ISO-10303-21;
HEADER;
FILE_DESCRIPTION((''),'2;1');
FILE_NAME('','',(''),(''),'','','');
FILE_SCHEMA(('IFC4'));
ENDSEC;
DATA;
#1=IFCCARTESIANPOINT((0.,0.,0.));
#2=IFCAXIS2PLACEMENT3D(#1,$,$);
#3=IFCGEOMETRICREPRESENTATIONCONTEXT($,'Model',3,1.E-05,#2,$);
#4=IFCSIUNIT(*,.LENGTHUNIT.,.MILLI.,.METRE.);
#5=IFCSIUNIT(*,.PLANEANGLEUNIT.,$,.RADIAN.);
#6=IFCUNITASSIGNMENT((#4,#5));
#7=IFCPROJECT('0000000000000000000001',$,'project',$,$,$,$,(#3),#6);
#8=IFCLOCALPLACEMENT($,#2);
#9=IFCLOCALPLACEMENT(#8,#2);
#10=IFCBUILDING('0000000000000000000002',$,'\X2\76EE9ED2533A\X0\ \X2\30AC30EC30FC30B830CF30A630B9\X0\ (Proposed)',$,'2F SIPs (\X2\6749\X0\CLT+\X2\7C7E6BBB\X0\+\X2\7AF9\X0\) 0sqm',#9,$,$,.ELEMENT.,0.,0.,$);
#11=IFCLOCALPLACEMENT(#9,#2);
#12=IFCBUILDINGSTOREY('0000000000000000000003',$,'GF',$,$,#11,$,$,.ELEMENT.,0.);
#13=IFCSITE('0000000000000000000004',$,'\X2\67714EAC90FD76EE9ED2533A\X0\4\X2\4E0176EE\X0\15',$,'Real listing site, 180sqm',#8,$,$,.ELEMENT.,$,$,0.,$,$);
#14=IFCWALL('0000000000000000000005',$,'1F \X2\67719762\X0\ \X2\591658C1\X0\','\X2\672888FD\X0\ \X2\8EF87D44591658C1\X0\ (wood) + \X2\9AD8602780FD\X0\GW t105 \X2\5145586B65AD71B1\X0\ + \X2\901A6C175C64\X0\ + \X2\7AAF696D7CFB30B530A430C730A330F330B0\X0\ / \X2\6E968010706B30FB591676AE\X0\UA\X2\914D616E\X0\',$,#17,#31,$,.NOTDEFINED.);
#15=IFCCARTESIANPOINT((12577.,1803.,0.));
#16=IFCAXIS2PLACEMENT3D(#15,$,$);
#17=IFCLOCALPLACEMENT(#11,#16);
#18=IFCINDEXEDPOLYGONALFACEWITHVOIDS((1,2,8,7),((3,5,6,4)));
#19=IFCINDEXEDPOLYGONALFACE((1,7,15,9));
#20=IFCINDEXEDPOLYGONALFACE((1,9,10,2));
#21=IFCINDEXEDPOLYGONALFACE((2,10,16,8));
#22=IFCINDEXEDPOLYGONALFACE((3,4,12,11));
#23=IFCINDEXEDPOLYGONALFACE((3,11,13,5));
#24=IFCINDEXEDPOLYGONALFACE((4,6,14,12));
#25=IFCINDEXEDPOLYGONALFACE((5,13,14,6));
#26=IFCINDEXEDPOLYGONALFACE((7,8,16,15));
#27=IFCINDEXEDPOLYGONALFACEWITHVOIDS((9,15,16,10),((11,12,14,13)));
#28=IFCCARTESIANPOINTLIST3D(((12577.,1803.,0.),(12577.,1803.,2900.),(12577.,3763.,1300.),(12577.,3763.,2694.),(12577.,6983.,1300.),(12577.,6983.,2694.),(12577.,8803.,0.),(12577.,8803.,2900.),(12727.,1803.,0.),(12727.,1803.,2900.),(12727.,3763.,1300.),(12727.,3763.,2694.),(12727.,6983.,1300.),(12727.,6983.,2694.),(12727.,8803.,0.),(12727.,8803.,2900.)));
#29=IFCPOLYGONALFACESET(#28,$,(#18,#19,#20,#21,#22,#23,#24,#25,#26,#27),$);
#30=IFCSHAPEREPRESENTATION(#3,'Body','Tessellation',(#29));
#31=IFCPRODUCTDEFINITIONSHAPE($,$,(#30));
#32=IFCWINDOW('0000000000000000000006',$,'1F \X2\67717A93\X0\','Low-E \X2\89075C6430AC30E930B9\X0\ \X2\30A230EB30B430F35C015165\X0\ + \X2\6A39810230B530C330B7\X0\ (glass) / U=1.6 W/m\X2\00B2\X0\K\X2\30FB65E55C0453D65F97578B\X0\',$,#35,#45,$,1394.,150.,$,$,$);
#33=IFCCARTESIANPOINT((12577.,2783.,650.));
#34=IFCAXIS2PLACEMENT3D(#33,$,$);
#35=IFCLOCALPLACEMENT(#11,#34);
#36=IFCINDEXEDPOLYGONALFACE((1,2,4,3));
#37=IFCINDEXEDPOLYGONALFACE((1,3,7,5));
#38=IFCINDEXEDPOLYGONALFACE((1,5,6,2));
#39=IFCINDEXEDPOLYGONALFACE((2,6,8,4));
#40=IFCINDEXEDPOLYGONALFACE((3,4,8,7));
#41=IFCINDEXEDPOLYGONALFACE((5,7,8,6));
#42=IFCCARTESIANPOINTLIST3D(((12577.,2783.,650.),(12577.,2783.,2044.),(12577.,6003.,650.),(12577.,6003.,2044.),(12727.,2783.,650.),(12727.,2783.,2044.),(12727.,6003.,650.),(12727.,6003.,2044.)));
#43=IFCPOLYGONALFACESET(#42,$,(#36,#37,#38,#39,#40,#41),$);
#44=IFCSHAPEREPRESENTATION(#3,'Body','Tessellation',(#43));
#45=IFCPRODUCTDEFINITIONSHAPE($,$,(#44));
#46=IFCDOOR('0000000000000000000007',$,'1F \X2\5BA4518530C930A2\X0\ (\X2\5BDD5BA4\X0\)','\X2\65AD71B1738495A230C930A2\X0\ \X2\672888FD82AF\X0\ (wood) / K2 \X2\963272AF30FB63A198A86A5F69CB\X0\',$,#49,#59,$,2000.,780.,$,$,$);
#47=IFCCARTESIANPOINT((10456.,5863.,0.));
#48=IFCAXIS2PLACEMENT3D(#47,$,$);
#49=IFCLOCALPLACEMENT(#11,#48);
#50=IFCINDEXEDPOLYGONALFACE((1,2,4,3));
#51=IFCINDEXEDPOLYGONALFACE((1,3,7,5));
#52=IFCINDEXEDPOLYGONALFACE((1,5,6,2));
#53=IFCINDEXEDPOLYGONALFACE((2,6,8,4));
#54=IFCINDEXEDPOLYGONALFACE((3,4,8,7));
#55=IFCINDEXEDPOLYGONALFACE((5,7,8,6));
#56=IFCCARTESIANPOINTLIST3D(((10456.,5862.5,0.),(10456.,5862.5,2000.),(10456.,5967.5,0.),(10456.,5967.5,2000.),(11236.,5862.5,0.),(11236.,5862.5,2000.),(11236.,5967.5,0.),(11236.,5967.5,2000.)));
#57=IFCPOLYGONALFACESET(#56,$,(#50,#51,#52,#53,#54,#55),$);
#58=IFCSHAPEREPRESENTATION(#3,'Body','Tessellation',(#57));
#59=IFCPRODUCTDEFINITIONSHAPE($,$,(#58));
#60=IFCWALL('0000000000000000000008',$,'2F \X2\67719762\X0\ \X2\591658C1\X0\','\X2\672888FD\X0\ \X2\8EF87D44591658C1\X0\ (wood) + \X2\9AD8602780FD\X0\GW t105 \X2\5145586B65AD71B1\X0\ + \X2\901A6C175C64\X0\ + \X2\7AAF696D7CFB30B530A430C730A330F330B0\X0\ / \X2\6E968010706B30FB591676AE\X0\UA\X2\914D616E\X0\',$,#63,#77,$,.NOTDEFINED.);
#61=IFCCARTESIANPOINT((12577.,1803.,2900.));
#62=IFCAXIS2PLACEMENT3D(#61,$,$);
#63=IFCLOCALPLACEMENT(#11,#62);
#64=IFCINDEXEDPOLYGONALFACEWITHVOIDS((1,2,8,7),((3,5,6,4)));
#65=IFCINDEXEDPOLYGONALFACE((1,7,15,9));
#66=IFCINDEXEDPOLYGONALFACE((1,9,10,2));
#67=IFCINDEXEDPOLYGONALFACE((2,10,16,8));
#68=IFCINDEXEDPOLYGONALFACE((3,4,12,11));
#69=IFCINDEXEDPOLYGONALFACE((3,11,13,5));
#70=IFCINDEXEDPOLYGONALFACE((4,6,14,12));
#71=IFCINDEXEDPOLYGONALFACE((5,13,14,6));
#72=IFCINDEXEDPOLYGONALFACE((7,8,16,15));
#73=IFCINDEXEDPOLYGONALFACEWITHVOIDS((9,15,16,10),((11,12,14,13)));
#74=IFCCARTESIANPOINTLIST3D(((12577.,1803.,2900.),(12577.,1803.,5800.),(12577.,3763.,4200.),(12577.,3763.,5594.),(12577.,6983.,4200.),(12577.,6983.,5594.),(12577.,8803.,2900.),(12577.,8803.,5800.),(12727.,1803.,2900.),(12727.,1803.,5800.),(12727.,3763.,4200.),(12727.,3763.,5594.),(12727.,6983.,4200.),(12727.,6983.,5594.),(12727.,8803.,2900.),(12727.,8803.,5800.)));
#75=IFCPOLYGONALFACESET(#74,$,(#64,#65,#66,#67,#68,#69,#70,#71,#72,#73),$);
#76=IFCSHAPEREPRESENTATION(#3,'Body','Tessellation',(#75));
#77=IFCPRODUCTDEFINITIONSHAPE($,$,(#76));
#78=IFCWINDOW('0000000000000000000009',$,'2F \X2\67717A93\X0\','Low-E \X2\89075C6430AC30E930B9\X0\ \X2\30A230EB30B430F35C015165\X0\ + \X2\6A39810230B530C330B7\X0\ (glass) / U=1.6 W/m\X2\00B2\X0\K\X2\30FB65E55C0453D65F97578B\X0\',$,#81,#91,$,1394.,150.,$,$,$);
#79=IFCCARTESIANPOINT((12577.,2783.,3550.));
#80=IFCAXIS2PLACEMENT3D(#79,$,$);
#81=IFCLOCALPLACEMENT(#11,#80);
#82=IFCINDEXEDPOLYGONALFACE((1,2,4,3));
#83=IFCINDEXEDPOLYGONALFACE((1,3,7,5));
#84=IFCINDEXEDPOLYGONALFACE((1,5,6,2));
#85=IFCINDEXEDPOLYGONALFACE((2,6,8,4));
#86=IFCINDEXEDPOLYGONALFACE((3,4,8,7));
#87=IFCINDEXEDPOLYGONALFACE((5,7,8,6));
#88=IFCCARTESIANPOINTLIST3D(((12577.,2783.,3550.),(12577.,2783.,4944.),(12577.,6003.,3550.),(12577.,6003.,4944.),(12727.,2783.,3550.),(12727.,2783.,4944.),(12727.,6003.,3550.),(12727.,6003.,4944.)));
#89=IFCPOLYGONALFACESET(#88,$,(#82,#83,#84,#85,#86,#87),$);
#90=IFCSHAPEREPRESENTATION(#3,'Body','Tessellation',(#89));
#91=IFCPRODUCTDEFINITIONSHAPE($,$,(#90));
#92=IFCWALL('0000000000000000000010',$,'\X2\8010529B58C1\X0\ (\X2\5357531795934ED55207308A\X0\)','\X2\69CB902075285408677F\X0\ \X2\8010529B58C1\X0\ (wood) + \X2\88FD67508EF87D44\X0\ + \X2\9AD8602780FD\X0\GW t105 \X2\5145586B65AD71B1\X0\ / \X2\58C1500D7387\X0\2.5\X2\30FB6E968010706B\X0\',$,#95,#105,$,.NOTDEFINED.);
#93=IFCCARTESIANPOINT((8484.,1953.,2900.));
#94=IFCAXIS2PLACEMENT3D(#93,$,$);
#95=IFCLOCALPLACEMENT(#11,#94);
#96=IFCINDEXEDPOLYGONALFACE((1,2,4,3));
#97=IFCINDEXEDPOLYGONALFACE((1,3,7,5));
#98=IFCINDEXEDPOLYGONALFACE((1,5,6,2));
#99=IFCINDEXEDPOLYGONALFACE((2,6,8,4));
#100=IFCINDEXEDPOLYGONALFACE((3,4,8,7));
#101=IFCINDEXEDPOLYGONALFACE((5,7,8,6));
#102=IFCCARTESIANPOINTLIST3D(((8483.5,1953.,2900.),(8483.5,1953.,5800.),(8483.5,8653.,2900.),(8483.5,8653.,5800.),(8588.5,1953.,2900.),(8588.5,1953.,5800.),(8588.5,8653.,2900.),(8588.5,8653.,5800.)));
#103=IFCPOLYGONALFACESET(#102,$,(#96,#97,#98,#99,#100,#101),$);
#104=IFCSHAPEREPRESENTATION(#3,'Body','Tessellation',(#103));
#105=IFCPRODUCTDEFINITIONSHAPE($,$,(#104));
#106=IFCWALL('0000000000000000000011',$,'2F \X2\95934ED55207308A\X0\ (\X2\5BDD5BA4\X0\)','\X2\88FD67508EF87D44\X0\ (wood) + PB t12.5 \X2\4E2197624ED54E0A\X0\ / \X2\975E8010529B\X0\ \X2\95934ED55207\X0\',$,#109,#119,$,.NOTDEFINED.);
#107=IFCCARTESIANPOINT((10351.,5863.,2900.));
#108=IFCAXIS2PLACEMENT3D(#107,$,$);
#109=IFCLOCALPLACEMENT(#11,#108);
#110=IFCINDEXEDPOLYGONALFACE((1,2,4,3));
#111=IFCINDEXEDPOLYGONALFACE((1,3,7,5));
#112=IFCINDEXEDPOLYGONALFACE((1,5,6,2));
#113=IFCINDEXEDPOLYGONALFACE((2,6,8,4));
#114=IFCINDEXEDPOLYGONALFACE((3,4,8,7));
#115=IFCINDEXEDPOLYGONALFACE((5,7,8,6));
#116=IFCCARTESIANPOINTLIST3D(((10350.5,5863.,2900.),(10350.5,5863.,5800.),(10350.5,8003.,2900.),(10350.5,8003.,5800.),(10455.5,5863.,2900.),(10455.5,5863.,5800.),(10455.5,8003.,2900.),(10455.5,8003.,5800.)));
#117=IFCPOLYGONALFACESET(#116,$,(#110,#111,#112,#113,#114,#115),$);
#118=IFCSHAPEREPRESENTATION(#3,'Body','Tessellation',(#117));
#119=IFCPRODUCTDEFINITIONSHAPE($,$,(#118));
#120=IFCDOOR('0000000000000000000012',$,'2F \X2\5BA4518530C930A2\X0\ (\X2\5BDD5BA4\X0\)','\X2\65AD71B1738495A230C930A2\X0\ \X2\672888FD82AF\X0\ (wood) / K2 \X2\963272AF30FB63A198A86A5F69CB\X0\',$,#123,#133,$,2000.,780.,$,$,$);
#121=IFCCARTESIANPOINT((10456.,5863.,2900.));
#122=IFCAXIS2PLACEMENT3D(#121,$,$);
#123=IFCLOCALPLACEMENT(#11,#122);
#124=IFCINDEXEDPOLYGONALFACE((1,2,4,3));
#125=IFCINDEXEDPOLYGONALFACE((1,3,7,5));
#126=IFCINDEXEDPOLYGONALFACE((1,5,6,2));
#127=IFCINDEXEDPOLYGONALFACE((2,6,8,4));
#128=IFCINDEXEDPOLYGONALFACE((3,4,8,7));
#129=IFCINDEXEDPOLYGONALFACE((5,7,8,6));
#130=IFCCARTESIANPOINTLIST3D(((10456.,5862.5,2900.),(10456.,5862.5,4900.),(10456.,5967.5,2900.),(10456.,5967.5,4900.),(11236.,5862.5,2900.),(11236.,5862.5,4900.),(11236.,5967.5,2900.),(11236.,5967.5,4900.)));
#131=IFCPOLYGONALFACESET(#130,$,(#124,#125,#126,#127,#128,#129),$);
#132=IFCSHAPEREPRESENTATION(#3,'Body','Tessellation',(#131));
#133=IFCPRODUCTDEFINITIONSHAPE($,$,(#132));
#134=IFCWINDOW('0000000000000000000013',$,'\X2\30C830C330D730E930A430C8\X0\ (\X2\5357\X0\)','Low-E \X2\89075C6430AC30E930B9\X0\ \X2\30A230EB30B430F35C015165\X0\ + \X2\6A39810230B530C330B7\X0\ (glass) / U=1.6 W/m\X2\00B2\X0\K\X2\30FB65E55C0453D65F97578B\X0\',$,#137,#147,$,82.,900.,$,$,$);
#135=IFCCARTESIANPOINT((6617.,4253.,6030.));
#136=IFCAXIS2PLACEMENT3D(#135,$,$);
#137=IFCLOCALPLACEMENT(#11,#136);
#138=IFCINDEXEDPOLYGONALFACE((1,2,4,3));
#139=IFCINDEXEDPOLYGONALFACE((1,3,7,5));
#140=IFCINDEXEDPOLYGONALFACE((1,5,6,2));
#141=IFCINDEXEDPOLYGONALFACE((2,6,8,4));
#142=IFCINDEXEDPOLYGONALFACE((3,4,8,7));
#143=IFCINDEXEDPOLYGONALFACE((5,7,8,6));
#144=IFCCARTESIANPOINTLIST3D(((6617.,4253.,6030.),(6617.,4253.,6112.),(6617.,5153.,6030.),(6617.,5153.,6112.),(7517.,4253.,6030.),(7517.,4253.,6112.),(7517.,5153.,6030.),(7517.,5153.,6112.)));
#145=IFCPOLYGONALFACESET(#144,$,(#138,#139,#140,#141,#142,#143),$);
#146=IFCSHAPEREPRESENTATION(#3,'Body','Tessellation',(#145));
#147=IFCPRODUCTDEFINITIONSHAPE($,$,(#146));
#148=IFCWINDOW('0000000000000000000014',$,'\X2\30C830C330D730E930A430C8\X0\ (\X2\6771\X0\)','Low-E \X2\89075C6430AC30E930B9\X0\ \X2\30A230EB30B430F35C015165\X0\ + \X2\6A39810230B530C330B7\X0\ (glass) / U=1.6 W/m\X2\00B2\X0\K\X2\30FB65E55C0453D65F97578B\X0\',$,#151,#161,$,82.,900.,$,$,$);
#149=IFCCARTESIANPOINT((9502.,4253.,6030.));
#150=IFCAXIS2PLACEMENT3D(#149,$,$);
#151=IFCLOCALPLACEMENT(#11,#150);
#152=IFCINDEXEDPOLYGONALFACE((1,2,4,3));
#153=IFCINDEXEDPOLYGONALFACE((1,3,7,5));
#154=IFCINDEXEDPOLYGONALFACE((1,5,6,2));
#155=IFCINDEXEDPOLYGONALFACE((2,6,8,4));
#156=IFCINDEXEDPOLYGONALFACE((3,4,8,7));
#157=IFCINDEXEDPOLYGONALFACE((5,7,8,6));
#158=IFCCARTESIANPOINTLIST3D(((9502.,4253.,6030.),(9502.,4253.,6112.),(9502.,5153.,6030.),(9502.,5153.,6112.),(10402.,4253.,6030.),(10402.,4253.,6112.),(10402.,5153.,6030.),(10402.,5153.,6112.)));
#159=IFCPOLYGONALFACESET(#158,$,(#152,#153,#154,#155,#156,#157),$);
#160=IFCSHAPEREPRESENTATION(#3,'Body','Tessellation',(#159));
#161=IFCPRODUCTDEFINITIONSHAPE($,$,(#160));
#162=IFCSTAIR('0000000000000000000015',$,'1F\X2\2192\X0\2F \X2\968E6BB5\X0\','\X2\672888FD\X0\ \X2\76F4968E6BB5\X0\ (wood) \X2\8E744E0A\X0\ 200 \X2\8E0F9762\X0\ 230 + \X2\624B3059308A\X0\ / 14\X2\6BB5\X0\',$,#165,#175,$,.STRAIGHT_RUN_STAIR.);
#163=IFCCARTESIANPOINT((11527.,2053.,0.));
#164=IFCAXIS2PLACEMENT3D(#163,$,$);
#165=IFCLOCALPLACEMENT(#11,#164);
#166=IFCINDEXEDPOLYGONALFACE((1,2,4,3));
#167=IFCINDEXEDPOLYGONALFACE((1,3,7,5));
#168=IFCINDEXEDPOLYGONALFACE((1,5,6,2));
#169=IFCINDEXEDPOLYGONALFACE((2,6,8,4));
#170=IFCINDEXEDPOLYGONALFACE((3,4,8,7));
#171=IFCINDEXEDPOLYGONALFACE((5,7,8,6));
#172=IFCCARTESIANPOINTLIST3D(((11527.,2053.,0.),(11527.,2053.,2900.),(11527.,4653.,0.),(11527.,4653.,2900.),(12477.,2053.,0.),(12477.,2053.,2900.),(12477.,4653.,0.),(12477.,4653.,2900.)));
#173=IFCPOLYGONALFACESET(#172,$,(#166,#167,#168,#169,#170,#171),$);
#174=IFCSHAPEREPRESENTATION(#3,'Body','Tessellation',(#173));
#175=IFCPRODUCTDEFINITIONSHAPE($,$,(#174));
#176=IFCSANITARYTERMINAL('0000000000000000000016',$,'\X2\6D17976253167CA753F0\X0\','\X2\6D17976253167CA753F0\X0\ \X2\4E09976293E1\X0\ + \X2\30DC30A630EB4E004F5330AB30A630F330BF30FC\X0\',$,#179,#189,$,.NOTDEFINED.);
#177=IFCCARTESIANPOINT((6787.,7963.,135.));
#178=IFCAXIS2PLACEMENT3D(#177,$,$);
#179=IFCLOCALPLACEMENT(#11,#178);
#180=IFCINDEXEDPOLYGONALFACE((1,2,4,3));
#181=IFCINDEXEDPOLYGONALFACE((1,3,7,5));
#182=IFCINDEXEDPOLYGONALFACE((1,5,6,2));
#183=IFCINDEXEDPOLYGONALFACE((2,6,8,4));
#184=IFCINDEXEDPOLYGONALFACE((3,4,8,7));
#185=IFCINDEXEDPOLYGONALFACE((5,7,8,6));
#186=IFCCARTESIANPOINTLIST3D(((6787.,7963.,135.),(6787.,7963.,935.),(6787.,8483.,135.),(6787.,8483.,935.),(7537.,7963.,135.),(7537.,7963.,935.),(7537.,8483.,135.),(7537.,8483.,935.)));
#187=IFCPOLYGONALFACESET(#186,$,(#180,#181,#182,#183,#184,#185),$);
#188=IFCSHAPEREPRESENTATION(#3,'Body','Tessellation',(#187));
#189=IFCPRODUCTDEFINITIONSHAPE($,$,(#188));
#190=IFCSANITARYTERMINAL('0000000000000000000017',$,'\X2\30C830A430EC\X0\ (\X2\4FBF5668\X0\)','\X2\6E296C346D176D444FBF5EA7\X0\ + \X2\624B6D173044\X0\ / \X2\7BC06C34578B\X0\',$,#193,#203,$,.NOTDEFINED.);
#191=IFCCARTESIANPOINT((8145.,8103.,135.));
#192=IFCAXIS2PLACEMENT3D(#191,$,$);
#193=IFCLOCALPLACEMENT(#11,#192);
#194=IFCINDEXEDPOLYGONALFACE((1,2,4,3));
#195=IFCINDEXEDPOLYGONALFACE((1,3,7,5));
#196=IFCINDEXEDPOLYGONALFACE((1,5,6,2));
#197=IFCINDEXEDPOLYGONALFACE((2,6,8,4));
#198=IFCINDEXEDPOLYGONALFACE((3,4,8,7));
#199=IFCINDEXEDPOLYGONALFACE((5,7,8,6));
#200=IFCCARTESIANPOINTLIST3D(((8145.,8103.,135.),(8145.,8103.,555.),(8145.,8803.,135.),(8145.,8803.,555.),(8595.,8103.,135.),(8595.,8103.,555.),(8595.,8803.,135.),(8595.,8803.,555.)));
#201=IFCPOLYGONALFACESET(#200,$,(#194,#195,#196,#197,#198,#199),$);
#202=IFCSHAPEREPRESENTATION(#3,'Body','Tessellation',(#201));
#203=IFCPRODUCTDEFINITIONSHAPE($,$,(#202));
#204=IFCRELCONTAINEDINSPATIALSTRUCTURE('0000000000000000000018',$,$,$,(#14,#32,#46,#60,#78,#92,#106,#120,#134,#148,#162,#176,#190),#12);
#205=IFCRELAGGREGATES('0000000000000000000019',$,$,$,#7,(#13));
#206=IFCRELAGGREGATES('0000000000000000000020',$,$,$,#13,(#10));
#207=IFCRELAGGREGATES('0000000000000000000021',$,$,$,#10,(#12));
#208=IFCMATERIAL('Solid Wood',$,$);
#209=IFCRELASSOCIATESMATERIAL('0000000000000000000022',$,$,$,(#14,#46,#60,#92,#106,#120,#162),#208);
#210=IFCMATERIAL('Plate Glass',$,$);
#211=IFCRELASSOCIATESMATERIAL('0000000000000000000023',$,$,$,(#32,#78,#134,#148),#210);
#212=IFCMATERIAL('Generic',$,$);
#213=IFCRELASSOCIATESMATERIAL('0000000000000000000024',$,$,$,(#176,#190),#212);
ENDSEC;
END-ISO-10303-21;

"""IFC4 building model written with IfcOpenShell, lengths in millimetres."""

from ifc_helpers import new_model, si_unit, frame, frame_2d, origin, place, context, project, spatial, rectangle, extrude, material, element, fill, save


model = new_model("IFC4")

# Units and contexts
model_context = context("Model", 3, precision=1e-05, world=origin())
ifc_project = project(units=[si_unit("LENGTHUNIT", "METRE", prefix="MILLI"), si_unit("PLANEANGLEUNIT", "RADIAN")], contexts=[model_context])

# Site, building, storey
site_placement = place(None, origin())
site = spatial("IfcSite", under=ifc_project, at=site_placement, Name="東京都目黒区4丁目15", ObjectType="Real listing site, 180sqm", CompositionType="ELEMENT", RefElevation=0.0)
building_placement = place(site_placement, origin())
building = spatial("IfcBuilding", under=site, at=building_placement, Name="目黒区 ガレージハウス (Proposed)", ObjectType="2F SIPs (杉CLT+籾殻+竹) 0sqm", CompositionType="ELEMENT", ElevationOfRefHeight=0.0, ElevationOfTerrain=0.0)
storey_placement = place(building_placement, origin())
storey = spatial("IfcBuildingStorey", under=building, at=storey_placement, Name="GF", CompositionType="ELEMENT", Elevation=0.0)

# Wall, opening, window
ifc_material_1 = material(Name="Solid Wood")
wall_1_placement = place(storey_placement, frame((12577.0, 1803.0, 0.0)))
wall_1 = element("IfcWall", 1, at=wall_1_placement, inside=storey, material=ifc_material_1, Name="1F 東面 外壁", Description="木製 軸組外壁 (wood) + 高性能GW t105 充填断熱 + 通気層 + 窯業系サイディング / 準耐火・外皮UA配慮", PredefinedType="NOTDEFINED", context=model_context, shape_type="SweptSolid", body=[
    extrude(rectangle(XDim=150.0, YDim=7000.0, at=frame_2d((75.0, 3500.0))), frame((12577.0, 1803.0, 0.0)), (0.0, 0.0, 1.0), 2900.0),
])
opening_1_placement = place(storey_placement, frame((12577.0, 2783.0, 650.0)))
opening_1 = element("IfcOpeningElement", 2, at=opening_1_placement, cuts=wall_1, PredefinedType="NOTDEFINED", context=model_context, shape_type="SweptSolid", body=[
    extrude(rectangle(XDim=150.0, YDim=3220.0, at=frame_2d((75.0, 1610.0))), frame((12577.0, 2783.0, 650.0)), (0.0, 0.0, 1.0), 1394.0),
])
ifc_material_2 = material(Name="Plate Glass")
window_1_placement = place(storey_placement, frame((12577.0, 2783.0, 650.0)))
window_1 = element("IfcWindow", 3, at=window_1_placement, inside=storey, material=ifc_material_2, Name="1F 東窓", Description="Low-E 複層ガラス アルゴン封入 + 樹脂サッシ (glass) / U=1.6 W/m²K・日射取得型", OverallHeight=1394.0, OverallWidth=150.0, context=model_context, shape_type="SweptSolid", body=[
    extrude(rectangle(XDim=150.0, YDim=3220.0, at=frame_2d((75.0, 1610.0))), frame((12577.0, 2783.0, 650.0)), (0.0, 0.0, 1.0), 1394.0),
])
fill(opening_1, window_1)

# Door
door_1_placement = place(storey_placement, frame((10456.0, 5863.0, 0.0)))
element("IfcDoor", 4, at=door_1_placement, inside=storey, material=ifc_material_1, Name="1F 室内ドア (寝室)", Description="断熱玄関ドア 木製芯 (wood) / K2 防犯・採風機構", OverallHeight=2000.0, OverallWidth=780.0, context=model_context, shape_type="SweptSolid", body=[
    extrude(rectangle(XDim=780.0, YDim=105.0, at=frame_2d((390.0, 52.0))), frame((10456.0, 5863.0, 0.0)), (0.0, 0.0, 1.0), 2000.0),
])

# Wall, opening, window
wall_2_placement = place(storey_placement, frame((12577.0, 1803.0, 2900.0)))
wall_2 = element("IfcWall", 5, at=wall_2_placement, inside=storey, material=ifc_material_1, Name="2F 東面 外壁", Description="木製 軸組外壁 (wood) + 高性能GW t105 充填断熱 + 通気層 + 窯業系サイディング / 準耐火・外皮UA配慮", PredefinedType="NOTDEFINED", context=model_context, shape_type="SweptSolid", body=[
    extrude(rectangle(XDim=150.0, YDim=7000.0, at=frame_2d((75.0, 3500.0))), frame((12577.0, 1803.0, 2900.0)), (0.0, 0.0, 1.0), 2900.0),
])
opening_2_placement = place(storey_placement, frame((12577.0, 2783.0, 3550.0)))
opening_2 = element("IfcOpeningElement", 6, at=opening_2_placement, cuts=wall_2, PredefinedType="NOTDEFINED", context=model_context, shape_type="SweptSolid", body=[
    extrude(rectangle(XDim=150.0, YDim=3220.0, at=frame_2d((75.0, 1610.0))), frame((12577.0, 2783.0, 3550.0)), (0.0, 0.0, 1.0), 1394.0),
])
window_2_placement = place(storey_placement, frame((12577.0, 2783.0, 3550.0)))
window_2 = element("IfcWindow", 7, at=window_2_placement, inside=storey, material=ifc_material_2, Name="2F 東窓", Description="Low-E 複層ガラス アルゴン封入 + 樹脂サッシ (glass) / U=1.6 W/m²K・日射取得型", OverallHeight=1394.0, OverallWidth=150.0, context=model_context, shape_type="SweptSolid", body=[
    extrude(rectangle(XDim=150.0, YDim=3220.0, at=frame_2d((75.0, 1610.0))), frame((12577.0, 2783.0, 3550.0)), (0.0, 0.0, 1.0), 1394.0),
])
fill(opening_2, window_2)

# Walls
wall_3_placement = place(storey_placement, frame((8484.0, 1953.0, 2900.0)))
element("IfcWall", 8, at=wall_3_placement, inside=storey, material=ifc_material_1, Name="耐力壁 (南北間仕切り)", Description="構造用合板 耐力壁 (wood) + 製材軸組 + 高性能GW t105 充填断熱 / 壁倍率2.5・準耐火", PredefinedType="NOTDEFINED", context=model_context, shape_type="SweptSolid", body=[
    extrude(rectangle(XDim=105.0, YDim=6700.0, at=frame_2d((52.0, 3350.0))), frame((8484.0, 1953.0, 2900.0)), (0.0, 0.0, 1.0), 2900.0),
])
wall_4_placement = place(storey_placement, frame((10351.0, 5863.0, 2900.0)))
element("IfcWall", 9, at=wall_4_placement, inside=storey, material=ifc_material_1, Name="2F 間仕切り (寝室)", Description="製材軸組 (wood) + PB t12.5 両面仕上 / 非耐力 間仕切", PredefinedType="NOTDEFINED", context=model_context, shape_type="SweptSolid", body=[
    extrude(rectangle(XDim=105.0, YDim=2140.0, at=frame_2d((52.0, 1070.0))), frame((10351.0, 5863.0, 2900.0)), (0.0, 0.0, 1.0), 2900.0),
])

# Door
door_2_placement = place(storey_placement, frame((10456.0, 5863.0, 2900.0)))
element("IfcDoor", 10, at=door_2_placement, inside=storey, material=ifc_material_1, Name="2F 室内ドア (寝室)", Description="断熱玄関ドア 木製芯 (wood) / K2 防犯・採風機構", OverallHeight=2000.0, OverallWidth=780.0, context=model_context, shape_type="SweptSolid", body=[
    extrude(rectangle(XDim=780.0, YDim=105.0, at=frame_2d((390.0, 52.0))), frame((10456.0, 5863.0, 2900.0)), (0.0, 0.0, 1.0), 2000.0),
])

# Windows
window_3_placement = place(storey_placement, frame((6617.0, 4253.0, 6030.0)))
element("IfcWindow", 11, at=window_3_placement, inside=storey, material=ifc_material_2, Name="トップライト (南)", Description="Low-E 複層ガラス アルゴン封入 + 樹脂サッシ (glass) / U=1.6 W/m²K・日射取得型", OverallHeight=82.0, OverallWidth=900.0, context=model_context, shape_type="SweptSolid", body=[
    extrude(rectangle(XDim=900.0, YDim=900.0, at=frame_2d((450.0, 450.0))), frame((6617.0, 4253.0, 6030.0)), (0.0, 0.0, 1.0), 82.0),
])
window_4_placement = place(storey_placement, frame((9502.0, 4253.0, 6030.0)))
element("IfcWindow", 12, at=window_4_placement, inside=storey, material=ifc_material_2, Name="トップライト (東)", Description="Low-E 複層ガラス アルゴン封入 + 樹脂サッシ (glass) / U=1.6 W/m²K・日射取得型", OverallHeight=82.0, OverallWidth=900.0, context=model_context, shape_type="SweptSolid", body=[
    extrude(rectangle(XDim=900.0, YDim=900.0, at=frame_2d((450.0, 450.0))), frame((9502.0, 4253.0, 6030.0)), (0.0, 0.0, 1.0), 82.0),
])

# Stair
stair_placement = place(storey_placement, frame((11527.0, 2053.0, 0.0)))
element("IfcStair", 13, at=stair_placement, inside=storey, material=ifc_material_1, Name="1F→2F 階段", Description="木製 直階段 (wood) 蹴上 200 踏面 230 + 手すり / 14段", PredefinedType="STRAIGHT_RUN_STAIR", context=model_context, shape_type="SweptSolid", body=[
    extrude(rectangle(XDim=950.0, YDim=2600.0, at=frame_2d((475.0, 1300.0))), frame((11527.0, 2053.0, 0.0)), (0.0, 0.0, 1.0), 2900.0),
])

# Sanitary terminals
ifc_material_3 = material(Name="Generic")
sanitary_terminal_1_placement = place(storey_placement, frame((6787.0, 7963.0, 135.0)))
element("IfcSanitaryTerminal", 14, at=sanitary_terminal_1_placement, inside=storey, material=ifc_material_3, Name="洗面化粧台", Description="洗面化粧台 三面鏡 + ボウル一体カウンター", PredefinedType="NOTDEFINED", context=model_context, shape_type="SweptSolid", body=[
    extrude(rectangle(XDim=750.0, YDim=520.0, at=frame_2d((375.0, 260.0))), frame((6787.0, 7963.0, 135.0)), (0.0, 0.0, 1.0), 800.0),
])
sanitary_terminal_2_placement = place(storey_placement, frame((8145.0, 8103.0, 135.0)))
element("IfcSanitaryTerminal", 15, at=sanitary_terminal_2_placement, inside=storey, material=ifc_material_3, Name="トイレ (便器)", Description="温水洗浄便座 + 手洗い / 節水型", PredefinedType="NOTDEFINED", context=model_context, shape_type="SweptSolid", body=[
    extrude(rectangle(XDim=450.0, YDim=700.0, at=frame_2d((225.0, 350.0))), frame((8145.0, 8103.0, 135.0)), (0.0, 0.0, 1.0), 420.0),
])

save(model, "model.ifc")
